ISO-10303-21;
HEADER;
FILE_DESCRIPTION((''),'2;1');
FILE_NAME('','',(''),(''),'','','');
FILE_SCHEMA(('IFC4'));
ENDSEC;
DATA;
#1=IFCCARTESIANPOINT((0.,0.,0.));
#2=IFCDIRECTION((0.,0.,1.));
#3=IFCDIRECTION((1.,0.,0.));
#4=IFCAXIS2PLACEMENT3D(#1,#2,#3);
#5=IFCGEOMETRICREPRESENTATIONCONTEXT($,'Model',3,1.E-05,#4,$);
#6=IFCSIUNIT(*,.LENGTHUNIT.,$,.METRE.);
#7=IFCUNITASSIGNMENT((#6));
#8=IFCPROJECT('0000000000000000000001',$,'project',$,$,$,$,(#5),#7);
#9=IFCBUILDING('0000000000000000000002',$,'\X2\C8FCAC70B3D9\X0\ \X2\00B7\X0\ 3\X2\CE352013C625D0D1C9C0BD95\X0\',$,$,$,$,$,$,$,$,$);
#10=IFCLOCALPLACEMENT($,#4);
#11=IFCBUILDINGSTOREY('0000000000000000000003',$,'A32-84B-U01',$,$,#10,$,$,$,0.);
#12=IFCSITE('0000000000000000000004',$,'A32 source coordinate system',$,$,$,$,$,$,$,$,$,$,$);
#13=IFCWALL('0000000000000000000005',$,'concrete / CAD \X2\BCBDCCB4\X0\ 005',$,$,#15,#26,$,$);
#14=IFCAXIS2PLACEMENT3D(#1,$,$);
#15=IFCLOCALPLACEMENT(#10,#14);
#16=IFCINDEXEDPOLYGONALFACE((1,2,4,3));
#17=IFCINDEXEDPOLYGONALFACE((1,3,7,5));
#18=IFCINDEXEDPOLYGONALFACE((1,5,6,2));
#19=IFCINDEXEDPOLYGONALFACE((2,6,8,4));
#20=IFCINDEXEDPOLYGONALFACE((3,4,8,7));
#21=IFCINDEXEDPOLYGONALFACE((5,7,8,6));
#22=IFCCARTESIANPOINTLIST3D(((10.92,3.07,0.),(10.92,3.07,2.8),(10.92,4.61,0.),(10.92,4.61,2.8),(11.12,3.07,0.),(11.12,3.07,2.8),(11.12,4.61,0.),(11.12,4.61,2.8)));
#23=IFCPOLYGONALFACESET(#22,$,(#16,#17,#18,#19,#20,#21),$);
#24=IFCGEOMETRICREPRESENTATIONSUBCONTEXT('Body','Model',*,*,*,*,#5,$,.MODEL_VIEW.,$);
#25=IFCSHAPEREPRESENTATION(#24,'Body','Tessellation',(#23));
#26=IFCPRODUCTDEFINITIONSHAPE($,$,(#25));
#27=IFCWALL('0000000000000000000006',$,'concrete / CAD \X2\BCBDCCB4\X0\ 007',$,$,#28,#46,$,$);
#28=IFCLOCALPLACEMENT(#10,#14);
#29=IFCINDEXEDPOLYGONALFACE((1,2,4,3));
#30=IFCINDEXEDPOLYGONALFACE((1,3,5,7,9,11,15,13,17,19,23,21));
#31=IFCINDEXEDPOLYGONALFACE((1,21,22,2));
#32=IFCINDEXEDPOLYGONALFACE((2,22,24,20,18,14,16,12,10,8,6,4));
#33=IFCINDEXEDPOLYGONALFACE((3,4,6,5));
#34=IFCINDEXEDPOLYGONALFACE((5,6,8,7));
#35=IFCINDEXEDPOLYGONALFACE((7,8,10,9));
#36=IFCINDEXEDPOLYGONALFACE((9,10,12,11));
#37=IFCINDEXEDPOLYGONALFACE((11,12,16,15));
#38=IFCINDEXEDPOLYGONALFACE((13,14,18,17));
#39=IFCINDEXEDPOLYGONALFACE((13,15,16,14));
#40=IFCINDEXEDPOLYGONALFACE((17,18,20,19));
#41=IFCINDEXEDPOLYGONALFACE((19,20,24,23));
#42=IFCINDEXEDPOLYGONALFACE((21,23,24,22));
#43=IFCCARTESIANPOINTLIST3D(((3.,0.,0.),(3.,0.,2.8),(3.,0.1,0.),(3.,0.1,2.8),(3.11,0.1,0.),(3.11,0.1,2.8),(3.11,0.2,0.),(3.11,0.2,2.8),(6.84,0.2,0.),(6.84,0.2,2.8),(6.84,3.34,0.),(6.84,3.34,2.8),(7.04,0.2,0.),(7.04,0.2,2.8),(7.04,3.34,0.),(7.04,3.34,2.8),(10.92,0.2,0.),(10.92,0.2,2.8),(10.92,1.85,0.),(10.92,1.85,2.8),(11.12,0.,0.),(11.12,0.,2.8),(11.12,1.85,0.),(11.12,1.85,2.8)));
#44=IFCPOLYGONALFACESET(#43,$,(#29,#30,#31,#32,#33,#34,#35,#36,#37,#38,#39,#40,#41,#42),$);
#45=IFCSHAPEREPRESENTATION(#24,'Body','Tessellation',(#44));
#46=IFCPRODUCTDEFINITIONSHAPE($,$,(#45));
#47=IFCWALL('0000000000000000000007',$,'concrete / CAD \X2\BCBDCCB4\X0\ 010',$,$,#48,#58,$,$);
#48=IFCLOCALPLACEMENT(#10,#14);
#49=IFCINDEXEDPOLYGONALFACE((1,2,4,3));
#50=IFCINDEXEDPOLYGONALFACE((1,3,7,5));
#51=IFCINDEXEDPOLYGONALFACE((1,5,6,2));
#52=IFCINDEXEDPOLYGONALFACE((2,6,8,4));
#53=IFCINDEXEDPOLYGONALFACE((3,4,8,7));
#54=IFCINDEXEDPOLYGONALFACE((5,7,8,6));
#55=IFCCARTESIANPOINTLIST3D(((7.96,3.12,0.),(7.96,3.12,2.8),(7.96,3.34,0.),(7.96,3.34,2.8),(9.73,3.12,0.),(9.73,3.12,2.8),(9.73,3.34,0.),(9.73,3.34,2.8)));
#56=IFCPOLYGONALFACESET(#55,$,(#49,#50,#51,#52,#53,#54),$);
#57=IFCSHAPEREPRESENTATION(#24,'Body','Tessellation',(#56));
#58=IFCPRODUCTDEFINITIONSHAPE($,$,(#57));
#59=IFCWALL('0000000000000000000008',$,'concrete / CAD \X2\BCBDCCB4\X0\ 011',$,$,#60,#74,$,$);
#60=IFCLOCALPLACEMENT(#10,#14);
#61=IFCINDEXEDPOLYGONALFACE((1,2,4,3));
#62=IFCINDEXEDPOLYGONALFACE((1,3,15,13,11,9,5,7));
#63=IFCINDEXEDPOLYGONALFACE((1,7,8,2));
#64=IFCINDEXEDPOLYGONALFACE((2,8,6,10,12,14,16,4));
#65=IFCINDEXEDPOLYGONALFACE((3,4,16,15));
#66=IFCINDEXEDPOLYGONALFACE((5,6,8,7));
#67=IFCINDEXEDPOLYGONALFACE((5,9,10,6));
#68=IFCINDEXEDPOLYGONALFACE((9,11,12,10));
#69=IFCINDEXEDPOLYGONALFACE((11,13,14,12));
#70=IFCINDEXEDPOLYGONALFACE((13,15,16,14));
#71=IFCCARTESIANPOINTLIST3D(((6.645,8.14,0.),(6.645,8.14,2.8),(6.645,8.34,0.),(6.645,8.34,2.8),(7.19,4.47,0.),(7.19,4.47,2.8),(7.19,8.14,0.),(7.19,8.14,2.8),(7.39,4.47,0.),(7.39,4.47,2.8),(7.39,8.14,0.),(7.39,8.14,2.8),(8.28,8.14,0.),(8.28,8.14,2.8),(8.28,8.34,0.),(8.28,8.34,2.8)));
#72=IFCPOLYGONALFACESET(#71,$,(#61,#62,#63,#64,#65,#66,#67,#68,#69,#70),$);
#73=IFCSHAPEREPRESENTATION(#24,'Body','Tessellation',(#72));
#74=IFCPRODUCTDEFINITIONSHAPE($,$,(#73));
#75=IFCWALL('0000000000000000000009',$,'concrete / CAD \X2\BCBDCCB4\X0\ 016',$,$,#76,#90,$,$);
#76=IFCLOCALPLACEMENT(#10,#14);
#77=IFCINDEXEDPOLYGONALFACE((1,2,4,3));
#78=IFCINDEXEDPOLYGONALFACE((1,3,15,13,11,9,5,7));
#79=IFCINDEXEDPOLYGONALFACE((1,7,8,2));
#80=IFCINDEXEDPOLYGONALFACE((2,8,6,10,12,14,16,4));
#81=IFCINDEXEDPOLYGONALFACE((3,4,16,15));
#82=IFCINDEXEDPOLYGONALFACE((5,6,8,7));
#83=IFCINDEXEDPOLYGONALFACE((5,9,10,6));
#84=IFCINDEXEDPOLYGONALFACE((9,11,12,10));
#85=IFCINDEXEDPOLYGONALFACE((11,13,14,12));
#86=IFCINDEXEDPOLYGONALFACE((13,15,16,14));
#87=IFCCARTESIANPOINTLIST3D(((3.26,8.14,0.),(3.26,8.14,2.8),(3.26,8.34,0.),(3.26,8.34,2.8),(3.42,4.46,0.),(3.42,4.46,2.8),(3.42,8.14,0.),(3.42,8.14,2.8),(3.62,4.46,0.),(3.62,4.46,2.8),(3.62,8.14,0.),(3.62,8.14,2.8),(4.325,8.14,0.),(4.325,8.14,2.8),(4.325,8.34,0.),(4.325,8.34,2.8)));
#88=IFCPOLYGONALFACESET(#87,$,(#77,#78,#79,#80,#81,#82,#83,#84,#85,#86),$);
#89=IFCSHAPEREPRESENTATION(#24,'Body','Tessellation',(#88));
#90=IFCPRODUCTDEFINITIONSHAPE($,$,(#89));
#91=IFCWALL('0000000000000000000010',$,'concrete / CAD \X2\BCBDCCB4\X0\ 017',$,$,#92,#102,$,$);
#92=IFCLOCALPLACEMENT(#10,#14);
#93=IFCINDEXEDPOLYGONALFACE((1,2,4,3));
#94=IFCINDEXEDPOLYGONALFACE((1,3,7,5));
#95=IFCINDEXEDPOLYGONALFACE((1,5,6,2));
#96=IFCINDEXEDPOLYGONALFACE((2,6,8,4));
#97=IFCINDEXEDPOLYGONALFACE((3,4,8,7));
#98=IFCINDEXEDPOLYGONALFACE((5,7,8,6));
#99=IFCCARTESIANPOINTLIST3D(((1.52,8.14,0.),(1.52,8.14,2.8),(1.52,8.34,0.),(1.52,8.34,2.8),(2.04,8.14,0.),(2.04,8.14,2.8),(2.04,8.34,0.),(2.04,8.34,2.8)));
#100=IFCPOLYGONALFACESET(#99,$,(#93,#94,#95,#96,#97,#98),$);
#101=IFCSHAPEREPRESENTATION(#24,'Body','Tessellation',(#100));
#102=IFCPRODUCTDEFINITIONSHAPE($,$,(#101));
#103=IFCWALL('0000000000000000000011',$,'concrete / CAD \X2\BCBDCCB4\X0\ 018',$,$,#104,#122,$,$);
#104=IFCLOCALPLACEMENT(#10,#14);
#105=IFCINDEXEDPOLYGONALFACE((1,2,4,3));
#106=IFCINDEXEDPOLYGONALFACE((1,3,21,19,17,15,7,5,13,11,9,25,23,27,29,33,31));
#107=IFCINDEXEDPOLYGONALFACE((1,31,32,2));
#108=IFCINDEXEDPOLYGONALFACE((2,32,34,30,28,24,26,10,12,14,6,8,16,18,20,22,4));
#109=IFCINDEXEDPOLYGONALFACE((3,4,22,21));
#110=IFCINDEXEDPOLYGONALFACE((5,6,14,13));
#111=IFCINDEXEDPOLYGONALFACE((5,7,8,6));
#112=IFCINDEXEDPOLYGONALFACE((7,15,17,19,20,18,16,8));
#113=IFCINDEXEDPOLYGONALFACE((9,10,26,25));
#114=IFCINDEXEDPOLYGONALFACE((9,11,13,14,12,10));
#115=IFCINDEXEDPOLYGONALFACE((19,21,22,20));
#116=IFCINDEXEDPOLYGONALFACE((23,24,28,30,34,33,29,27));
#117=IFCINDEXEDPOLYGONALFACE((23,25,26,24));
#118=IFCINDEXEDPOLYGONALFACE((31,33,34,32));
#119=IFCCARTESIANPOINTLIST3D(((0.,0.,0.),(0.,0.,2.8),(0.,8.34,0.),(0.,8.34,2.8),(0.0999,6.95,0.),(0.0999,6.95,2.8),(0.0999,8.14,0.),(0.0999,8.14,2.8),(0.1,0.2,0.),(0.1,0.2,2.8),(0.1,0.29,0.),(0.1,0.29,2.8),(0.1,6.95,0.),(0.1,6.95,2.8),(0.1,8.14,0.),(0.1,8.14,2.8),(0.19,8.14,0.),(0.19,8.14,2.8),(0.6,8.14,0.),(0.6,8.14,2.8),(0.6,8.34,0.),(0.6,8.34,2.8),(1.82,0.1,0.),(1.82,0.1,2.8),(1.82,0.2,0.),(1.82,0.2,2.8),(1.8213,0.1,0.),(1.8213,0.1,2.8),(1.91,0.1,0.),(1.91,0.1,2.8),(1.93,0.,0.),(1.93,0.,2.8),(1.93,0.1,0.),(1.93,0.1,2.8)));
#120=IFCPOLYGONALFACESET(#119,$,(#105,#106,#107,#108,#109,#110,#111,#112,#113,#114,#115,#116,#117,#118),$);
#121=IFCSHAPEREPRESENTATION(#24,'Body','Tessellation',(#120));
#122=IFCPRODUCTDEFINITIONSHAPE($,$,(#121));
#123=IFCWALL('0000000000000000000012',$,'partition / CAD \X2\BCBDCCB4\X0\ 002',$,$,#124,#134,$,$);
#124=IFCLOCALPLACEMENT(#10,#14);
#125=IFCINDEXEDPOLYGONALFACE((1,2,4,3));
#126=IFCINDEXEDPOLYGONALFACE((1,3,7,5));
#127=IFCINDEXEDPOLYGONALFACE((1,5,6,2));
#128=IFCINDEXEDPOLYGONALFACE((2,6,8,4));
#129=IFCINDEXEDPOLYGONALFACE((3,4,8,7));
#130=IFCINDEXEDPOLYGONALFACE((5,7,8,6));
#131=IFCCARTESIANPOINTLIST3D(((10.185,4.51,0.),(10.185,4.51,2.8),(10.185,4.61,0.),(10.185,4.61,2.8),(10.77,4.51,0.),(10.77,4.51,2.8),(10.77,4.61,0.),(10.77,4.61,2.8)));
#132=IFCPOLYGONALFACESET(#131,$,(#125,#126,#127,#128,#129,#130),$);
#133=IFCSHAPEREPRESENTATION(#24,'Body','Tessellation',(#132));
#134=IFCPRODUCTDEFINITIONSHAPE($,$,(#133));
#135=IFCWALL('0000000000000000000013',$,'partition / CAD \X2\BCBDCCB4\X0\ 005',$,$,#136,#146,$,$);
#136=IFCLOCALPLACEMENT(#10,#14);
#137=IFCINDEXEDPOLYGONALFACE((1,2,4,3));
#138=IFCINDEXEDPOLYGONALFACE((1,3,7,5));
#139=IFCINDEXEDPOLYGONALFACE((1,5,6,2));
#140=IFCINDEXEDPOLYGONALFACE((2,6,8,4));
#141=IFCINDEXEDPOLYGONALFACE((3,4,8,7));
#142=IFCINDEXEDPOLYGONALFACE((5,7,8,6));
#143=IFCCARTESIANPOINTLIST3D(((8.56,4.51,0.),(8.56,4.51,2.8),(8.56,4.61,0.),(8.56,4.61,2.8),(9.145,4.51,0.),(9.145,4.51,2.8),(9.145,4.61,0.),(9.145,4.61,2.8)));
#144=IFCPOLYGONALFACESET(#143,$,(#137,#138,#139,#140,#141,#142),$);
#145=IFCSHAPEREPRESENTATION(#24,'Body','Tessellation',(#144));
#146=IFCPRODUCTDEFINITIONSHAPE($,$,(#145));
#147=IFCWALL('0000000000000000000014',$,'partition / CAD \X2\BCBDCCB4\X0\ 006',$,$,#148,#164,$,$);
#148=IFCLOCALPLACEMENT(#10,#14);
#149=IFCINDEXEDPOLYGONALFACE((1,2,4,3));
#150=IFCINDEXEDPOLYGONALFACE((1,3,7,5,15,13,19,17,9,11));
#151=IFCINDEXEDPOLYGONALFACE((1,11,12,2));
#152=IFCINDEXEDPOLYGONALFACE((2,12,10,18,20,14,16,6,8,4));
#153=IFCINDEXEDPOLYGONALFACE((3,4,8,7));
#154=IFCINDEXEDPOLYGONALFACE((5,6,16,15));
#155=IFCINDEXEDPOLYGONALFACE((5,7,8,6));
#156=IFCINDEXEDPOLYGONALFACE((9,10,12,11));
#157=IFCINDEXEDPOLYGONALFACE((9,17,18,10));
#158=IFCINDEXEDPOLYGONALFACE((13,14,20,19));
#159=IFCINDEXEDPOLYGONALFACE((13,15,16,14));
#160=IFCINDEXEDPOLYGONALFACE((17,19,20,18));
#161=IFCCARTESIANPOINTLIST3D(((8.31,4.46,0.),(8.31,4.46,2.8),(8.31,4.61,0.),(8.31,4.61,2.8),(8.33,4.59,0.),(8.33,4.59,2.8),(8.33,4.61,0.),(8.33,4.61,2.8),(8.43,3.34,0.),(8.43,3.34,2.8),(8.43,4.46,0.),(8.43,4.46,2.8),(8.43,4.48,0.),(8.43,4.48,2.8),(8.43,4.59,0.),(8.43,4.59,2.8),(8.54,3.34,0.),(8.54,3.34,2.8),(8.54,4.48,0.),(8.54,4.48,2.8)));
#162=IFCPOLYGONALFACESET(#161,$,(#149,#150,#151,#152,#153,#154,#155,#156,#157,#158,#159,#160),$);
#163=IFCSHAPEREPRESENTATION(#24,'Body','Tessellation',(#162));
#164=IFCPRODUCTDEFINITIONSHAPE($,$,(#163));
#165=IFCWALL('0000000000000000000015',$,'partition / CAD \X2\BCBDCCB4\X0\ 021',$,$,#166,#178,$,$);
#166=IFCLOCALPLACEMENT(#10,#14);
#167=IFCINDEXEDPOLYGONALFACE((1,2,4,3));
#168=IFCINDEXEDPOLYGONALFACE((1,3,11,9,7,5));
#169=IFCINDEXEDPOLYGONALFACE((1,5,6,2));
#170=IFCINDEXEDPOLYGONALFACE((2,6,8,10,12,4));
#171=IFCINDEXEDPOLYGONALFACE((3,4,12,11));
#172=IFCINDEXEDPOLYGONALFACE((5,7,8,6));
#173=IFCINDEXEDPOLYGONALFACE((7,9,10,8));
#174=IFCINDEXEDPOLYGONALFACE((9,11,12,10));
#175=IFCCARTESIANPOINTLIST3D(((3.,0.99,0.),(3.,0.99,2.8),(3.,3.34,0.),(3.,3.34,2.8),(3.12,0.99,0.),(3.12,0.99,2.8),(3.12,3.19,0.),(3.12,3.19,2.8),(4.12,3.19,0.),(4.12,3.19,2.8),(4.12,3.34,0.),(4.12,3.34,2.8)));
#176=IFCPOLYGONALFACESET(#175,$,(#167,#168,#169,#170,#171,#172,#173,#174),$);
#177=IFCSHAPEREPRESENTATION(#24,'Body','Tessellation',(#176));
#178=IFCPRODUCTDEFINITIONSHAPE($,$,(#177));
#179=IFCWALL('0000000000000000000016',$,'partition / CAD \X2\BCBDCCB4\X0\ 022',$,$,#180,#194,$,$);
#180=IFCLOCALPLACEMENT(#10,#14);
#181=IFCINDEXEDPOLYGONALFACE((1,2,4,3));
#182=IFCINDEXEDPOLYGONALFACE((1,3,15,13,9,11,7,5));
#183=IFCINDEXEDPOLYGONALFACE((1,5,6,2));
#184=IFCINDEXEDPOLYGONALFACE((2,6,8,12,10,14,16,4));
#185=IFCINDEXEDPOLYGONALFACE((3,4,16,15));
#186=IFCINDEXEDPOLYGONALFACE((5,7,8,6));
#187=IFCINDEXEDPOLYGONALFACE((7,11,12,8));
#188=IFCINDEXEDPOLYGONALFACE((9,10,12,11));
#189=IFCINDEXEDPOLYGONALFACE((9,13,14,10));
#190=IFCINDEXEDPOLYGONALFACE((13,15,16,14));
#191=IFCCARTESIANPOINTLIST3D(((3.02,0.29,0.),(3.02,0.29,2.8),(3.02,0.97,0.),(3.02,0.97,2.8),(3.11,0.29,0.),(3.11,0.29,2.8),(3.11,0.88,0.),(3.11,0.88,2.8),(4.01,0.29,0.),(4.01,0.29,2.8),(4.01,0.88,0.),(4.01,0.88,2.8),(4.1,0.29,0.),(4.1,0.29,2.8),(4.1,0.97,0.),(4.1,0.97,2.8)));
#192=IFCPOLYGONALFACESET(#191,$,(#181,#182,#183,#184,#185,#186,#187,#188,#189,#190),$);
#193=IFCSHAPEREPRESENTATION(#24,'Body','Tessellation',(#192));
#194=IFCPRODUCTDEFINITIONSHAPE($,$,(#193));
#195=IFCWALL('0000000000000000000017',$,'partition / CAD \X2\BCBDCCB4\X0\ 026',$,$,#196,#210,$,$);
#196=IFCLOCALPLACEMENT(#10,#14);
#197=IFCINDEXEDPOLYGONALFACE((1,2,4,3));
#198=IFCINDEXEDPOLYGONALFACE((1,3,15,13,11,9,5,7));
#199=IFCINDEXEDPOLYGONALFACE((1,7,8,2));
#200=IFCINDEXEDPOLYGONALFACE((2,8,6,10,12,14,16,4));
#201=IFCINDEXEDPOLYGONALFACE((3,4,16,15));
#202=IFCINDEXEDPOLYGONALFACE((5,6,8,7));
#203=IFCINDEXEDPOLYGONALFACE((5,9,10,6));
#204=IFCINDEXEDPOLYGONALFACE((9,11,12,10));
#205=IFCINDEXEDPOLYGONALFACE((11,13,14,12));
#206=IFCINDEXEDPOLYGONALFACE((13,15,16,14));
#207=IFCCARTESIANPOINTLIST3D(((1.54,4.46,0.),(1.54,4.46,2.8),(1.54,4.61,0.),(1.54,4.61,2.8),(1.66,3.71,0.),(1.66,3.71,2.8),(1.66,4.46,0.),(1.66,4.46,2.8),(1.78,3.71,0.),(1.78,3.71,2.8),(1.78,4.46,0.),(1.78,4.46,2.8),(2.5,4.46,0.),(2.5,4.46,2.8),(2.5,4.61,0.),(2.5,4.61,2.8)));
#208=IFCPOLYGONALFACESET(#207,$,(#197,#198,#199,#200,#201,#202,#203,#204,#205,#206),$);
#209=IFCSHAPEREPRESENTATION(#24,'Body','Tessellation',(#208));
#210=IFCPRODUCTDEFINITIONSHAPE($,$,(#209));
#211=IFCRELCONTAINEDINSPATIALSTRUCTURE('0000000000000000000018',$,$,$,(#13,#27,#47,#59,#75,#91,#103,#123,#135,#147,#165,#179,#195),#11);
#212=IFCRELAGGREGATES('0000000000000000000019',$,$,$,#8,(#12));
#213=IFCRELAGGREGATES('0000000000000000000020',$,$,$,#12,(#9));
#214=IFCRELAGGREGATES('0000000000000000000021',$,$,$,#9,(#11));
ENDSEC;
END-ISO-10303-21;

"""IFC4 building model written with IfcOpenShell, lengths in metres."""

from ifc_helpers import new_model, si_unit, origin, origin_with_axes, place, context, subcontext, project, spatial, polyline, outline, extrude, element, save


model = new_model("IFC4")

# Units and contexts
model_context = context("Model", 3, precision=1e-05, world=origin_with_axes())
body_context = subcontext(model_context, "Body", "Model", "MODEL_VIEW")
ifc_project = project(units=[si_unit("LENGTHUNIT", "METRE")], contexts=[model_context])

# Site, building, storey
site = spatial("IfcSite", under=ifc_project, Name="A32 source coordinate system")
building = spatial("IfcBuilding", under=site, Name="주거동 · 3층–옥탑지붕")
storey_placement = place(None, origin_with_axes())
storey = spatial("IfcBuildingStorey", under=building, at=storey_placement, Name="A32-84B-U01", Elevation=0.0)

# Walls
wall_1_placement = place(storey_placement, origin_with_axes())
element("IfcWall", 1, at=wall_1_placement, inside=storey, Name="concrete / CAD 벽체 005", context=body_context, shape_type="SweptSolid", body=[
    extrude(outline(polyline([(11.12, 3.07), (10.92, 3.07), (10.92, 4.61), (11.12, 4.61), (11.12, 3.07)])), origin(), (0.0, 0.0, 1.0), 2.8),
])
wall_2_placement = place(storey_placement, origin_with_axes())
element("IfcWall", 2, at=wall_2_placement, inside=storey, Name="concrete / CAD 벽체 007", context=body_context, shape_type="SweptSolid", body=[
    extrude(outline(polyline([(3.0, 0.0), (3.0, 0.1), (3.11, 0.1), (3.11, 0.2), (6.84, 0.2), (6.84, 3.34), (7.04, 3.34), (7.04, 0.2), (10.92, 0.2), (10.92, 1.85), (11.12, 1.85), (11.12, 0.0), (3.0, 0.0)])), origin(), (0.0, 0.0, 1.0), 2.8),
])
wall_3_placement = place(storey_placement, origin_with_axes())
element("IfcWall", 3, at=wall_3_placement, inside=storey, Name="concrete / CAD 벽체 010", context=body_context, shape_type="SweptSolid", body=[
    extrude(outline(polyline([(7.96, 3.12), (7.96, 3.34), (9.73, 3.34), (9.73, 3.12), (7.96, 3.12)])), origin(), (0.0, 0.0, 1.0), 2.8),
])
wall_4_placement = place(storey_placement, origin_with_axes())
element("IfcWall", 4, at=wall_4_placement, inside=storey, Name="concrete / CAD 벽체 011", context=body_context, shape_type="SweptSolid", body=[
    extrude(outline(polyline([(7.19, 8.14), (6.645, 8.14), (6.645, 8.34), (8.28, 8.34), (8.28, 8.14), (7.39, 8.14), (7.39, 4.47), (7.19, 4.47), (7.19, 8.14)])), origin(), (0.0, 0.0, 1.0), 2.8),
])
wall_5_placement = place(storey_placement, origin_with_axes())
element("IfcWall", 5, at=wall_5_placement, inside=storey, Name="concrete / CAD 벽체 016", context=body_context, shape_type="SweptSolid", body=[
    extrude(outline(polyline([(3.26, 8.14), (3.26, 8.34), (4.325, 8.34), (4.325, 8.14), (3.62, 8.14), (3.62, 4.46), (3.42, 4.46), (3.42, 8.14), (3.26, 8.14)])), origin(), (0.0, 0.0, 1.0), 2.8),
])
wall_6_placement = place(storey_placement, origin_with_axes())
element("IfcWall", 6, at=wall_6_placement, inside=storey, Name="concrete / CAD 벽체 017", context=body_context, shape_type="SweptSolid", body=[
    extrude(outline(polyline([(1.52, 8.34), (2.04, 8.34), (2.04, 8.14), (1.52, 8.14), (1.52, 8.34)])), origin(), (0.0, 0.0, 1.0), 2.8),
])
wall_7_placement = place(storey_placement, origin_with_axes())
element("IfcWall", 7, at=wall_7_placement, inside=storey, Name="concrete / CAD 벽체 018", context=body_context, shape_type="SweptSolid", body=[
    extrude(outline(polyline([(0.6, 8.34), (0.6, 8.14), (0.19, 8.14), (0.1, 8.14), (0.0999, 8.14), (0.0999, 6.95), (0.1, 6.95), (0.1, 0.29), (0.1, 0.2), (1.82, 0.2), (1.82, 0.1), (1.8213, 0.1), (1.91, 0.1), (1.93, 0.1), (1.93, 0.0), (0.0, 0.0), (0.0, 8.34), (-0.35, 8.34), (-0.35, 8.34), (0.6, 8.34)])), origin(), (0.0, 0.0, 1.0), 2.8),
])
wall_8_placement = place(storey_placement, origin_with_axes())
element("IfcWall", 8, at=wall_8_placement, inside=storey, Name="partition / CAD 벽체 002", context=body_context, shape_type="SweptSolid", body=[
    extrude(outline(polyline([(10.185, 4.51), (10.185, 4.61), (10.77, 4.61), (10.77, 4.51), (10.185, 4.51)])), origin(), (0.0, 0.0, 1.0), 2.8),
])
wall_9_placement = place(storey_placement, origin_with_axes())
element("IfcWall", 9, at=wall_9_placement, inside=storey, Name="partition / CAD 벽체 005", context=body_context, shape_type="SweptSolid", body=[
    extrude(outline(polyline([(8.56, 4.51), (8.56, 4.61), (9.145, 4.61), (9.145, 4.51), (8.56, 4.51)])), origin(), (0.0, 0.0, 1.0), 2.8),
])
wall_10_placement = place(storey_placement, origin_with_axes())
element("IfcWall", 10, at=wall_10_placement, inside=storey, Name="partition / CAD 벽체 006", context=body_context, shape_type="SweptSolid", body=[
    extrude(outline(polyline([(8.43, 4.46), (8.31, 4.46), (8.31, 4.61), (8.33, 4.61), (8.33, 4.59), (8.43, 4.59), (8.43, 4.48), (8.54, 4.48), (8.54, 3.34), (8.43, 3.34), (8.43, 4.46)])), origin(), (0.0, 0.0, 1.0), 2.8),
])
wall_11_placement = place(storey_placement, origin_with_axes())
element("IfcWall", 11, at=wall_11_placement, inside=storey, Name="partition / CAD 벽체 021", context=body_context, shape_type="SweptSolid", body=[
    extrude(outline(polyline([(4.12, 3.34), (4.12, 3.19), (3.12, 3.19), (3.12, 0.99), (3.0, 0.99), (3.0, 3.34), (4.12, 3.34)])), origin(), (0.0, 0.0, 1.0), 2.8),
])
wall_12_placement = place(storey_placement, origin_with_axes())
element("IfcWall", 12, at=wall_12_placement, inside=storey, Name="partition / CAD 벽체 022", context=body_context, shape_type="SweptSolid", body=[
    extrude(outline(polyline([(4.1, 0.97), (4.1, 0.29), (4.01, 0.29), (4.01, 0.88), (3.11, 0.88), (3.11, 0.29), (3.02, 0.29), (3.02, 0.97), (4.1, 0.97)])), origin(), (0.0, 0.0, 1.0), 2.8),
])
wall_13_placement = place(storey_placement, origin_with_axes())
element("IfcWall", 13, at=wall_13_placement, inside=storey, Name="partition / CAD 벽체 026", context=body_context, shape_type="SweptSolid", body=[
    extrude(outline(polyline([(1.54, 4.46), (1.54, 4.61), (2.5, 4.61), (2.5, 4.46), (1.78, 4.46), (1.78, 3.71), (1.66, 3.71), (1.66, 4.46), (1.54, 4.46)])), origin(), (0.0, 0.0, 1.0), 2.8),
])

save(model, "model.ifc")
